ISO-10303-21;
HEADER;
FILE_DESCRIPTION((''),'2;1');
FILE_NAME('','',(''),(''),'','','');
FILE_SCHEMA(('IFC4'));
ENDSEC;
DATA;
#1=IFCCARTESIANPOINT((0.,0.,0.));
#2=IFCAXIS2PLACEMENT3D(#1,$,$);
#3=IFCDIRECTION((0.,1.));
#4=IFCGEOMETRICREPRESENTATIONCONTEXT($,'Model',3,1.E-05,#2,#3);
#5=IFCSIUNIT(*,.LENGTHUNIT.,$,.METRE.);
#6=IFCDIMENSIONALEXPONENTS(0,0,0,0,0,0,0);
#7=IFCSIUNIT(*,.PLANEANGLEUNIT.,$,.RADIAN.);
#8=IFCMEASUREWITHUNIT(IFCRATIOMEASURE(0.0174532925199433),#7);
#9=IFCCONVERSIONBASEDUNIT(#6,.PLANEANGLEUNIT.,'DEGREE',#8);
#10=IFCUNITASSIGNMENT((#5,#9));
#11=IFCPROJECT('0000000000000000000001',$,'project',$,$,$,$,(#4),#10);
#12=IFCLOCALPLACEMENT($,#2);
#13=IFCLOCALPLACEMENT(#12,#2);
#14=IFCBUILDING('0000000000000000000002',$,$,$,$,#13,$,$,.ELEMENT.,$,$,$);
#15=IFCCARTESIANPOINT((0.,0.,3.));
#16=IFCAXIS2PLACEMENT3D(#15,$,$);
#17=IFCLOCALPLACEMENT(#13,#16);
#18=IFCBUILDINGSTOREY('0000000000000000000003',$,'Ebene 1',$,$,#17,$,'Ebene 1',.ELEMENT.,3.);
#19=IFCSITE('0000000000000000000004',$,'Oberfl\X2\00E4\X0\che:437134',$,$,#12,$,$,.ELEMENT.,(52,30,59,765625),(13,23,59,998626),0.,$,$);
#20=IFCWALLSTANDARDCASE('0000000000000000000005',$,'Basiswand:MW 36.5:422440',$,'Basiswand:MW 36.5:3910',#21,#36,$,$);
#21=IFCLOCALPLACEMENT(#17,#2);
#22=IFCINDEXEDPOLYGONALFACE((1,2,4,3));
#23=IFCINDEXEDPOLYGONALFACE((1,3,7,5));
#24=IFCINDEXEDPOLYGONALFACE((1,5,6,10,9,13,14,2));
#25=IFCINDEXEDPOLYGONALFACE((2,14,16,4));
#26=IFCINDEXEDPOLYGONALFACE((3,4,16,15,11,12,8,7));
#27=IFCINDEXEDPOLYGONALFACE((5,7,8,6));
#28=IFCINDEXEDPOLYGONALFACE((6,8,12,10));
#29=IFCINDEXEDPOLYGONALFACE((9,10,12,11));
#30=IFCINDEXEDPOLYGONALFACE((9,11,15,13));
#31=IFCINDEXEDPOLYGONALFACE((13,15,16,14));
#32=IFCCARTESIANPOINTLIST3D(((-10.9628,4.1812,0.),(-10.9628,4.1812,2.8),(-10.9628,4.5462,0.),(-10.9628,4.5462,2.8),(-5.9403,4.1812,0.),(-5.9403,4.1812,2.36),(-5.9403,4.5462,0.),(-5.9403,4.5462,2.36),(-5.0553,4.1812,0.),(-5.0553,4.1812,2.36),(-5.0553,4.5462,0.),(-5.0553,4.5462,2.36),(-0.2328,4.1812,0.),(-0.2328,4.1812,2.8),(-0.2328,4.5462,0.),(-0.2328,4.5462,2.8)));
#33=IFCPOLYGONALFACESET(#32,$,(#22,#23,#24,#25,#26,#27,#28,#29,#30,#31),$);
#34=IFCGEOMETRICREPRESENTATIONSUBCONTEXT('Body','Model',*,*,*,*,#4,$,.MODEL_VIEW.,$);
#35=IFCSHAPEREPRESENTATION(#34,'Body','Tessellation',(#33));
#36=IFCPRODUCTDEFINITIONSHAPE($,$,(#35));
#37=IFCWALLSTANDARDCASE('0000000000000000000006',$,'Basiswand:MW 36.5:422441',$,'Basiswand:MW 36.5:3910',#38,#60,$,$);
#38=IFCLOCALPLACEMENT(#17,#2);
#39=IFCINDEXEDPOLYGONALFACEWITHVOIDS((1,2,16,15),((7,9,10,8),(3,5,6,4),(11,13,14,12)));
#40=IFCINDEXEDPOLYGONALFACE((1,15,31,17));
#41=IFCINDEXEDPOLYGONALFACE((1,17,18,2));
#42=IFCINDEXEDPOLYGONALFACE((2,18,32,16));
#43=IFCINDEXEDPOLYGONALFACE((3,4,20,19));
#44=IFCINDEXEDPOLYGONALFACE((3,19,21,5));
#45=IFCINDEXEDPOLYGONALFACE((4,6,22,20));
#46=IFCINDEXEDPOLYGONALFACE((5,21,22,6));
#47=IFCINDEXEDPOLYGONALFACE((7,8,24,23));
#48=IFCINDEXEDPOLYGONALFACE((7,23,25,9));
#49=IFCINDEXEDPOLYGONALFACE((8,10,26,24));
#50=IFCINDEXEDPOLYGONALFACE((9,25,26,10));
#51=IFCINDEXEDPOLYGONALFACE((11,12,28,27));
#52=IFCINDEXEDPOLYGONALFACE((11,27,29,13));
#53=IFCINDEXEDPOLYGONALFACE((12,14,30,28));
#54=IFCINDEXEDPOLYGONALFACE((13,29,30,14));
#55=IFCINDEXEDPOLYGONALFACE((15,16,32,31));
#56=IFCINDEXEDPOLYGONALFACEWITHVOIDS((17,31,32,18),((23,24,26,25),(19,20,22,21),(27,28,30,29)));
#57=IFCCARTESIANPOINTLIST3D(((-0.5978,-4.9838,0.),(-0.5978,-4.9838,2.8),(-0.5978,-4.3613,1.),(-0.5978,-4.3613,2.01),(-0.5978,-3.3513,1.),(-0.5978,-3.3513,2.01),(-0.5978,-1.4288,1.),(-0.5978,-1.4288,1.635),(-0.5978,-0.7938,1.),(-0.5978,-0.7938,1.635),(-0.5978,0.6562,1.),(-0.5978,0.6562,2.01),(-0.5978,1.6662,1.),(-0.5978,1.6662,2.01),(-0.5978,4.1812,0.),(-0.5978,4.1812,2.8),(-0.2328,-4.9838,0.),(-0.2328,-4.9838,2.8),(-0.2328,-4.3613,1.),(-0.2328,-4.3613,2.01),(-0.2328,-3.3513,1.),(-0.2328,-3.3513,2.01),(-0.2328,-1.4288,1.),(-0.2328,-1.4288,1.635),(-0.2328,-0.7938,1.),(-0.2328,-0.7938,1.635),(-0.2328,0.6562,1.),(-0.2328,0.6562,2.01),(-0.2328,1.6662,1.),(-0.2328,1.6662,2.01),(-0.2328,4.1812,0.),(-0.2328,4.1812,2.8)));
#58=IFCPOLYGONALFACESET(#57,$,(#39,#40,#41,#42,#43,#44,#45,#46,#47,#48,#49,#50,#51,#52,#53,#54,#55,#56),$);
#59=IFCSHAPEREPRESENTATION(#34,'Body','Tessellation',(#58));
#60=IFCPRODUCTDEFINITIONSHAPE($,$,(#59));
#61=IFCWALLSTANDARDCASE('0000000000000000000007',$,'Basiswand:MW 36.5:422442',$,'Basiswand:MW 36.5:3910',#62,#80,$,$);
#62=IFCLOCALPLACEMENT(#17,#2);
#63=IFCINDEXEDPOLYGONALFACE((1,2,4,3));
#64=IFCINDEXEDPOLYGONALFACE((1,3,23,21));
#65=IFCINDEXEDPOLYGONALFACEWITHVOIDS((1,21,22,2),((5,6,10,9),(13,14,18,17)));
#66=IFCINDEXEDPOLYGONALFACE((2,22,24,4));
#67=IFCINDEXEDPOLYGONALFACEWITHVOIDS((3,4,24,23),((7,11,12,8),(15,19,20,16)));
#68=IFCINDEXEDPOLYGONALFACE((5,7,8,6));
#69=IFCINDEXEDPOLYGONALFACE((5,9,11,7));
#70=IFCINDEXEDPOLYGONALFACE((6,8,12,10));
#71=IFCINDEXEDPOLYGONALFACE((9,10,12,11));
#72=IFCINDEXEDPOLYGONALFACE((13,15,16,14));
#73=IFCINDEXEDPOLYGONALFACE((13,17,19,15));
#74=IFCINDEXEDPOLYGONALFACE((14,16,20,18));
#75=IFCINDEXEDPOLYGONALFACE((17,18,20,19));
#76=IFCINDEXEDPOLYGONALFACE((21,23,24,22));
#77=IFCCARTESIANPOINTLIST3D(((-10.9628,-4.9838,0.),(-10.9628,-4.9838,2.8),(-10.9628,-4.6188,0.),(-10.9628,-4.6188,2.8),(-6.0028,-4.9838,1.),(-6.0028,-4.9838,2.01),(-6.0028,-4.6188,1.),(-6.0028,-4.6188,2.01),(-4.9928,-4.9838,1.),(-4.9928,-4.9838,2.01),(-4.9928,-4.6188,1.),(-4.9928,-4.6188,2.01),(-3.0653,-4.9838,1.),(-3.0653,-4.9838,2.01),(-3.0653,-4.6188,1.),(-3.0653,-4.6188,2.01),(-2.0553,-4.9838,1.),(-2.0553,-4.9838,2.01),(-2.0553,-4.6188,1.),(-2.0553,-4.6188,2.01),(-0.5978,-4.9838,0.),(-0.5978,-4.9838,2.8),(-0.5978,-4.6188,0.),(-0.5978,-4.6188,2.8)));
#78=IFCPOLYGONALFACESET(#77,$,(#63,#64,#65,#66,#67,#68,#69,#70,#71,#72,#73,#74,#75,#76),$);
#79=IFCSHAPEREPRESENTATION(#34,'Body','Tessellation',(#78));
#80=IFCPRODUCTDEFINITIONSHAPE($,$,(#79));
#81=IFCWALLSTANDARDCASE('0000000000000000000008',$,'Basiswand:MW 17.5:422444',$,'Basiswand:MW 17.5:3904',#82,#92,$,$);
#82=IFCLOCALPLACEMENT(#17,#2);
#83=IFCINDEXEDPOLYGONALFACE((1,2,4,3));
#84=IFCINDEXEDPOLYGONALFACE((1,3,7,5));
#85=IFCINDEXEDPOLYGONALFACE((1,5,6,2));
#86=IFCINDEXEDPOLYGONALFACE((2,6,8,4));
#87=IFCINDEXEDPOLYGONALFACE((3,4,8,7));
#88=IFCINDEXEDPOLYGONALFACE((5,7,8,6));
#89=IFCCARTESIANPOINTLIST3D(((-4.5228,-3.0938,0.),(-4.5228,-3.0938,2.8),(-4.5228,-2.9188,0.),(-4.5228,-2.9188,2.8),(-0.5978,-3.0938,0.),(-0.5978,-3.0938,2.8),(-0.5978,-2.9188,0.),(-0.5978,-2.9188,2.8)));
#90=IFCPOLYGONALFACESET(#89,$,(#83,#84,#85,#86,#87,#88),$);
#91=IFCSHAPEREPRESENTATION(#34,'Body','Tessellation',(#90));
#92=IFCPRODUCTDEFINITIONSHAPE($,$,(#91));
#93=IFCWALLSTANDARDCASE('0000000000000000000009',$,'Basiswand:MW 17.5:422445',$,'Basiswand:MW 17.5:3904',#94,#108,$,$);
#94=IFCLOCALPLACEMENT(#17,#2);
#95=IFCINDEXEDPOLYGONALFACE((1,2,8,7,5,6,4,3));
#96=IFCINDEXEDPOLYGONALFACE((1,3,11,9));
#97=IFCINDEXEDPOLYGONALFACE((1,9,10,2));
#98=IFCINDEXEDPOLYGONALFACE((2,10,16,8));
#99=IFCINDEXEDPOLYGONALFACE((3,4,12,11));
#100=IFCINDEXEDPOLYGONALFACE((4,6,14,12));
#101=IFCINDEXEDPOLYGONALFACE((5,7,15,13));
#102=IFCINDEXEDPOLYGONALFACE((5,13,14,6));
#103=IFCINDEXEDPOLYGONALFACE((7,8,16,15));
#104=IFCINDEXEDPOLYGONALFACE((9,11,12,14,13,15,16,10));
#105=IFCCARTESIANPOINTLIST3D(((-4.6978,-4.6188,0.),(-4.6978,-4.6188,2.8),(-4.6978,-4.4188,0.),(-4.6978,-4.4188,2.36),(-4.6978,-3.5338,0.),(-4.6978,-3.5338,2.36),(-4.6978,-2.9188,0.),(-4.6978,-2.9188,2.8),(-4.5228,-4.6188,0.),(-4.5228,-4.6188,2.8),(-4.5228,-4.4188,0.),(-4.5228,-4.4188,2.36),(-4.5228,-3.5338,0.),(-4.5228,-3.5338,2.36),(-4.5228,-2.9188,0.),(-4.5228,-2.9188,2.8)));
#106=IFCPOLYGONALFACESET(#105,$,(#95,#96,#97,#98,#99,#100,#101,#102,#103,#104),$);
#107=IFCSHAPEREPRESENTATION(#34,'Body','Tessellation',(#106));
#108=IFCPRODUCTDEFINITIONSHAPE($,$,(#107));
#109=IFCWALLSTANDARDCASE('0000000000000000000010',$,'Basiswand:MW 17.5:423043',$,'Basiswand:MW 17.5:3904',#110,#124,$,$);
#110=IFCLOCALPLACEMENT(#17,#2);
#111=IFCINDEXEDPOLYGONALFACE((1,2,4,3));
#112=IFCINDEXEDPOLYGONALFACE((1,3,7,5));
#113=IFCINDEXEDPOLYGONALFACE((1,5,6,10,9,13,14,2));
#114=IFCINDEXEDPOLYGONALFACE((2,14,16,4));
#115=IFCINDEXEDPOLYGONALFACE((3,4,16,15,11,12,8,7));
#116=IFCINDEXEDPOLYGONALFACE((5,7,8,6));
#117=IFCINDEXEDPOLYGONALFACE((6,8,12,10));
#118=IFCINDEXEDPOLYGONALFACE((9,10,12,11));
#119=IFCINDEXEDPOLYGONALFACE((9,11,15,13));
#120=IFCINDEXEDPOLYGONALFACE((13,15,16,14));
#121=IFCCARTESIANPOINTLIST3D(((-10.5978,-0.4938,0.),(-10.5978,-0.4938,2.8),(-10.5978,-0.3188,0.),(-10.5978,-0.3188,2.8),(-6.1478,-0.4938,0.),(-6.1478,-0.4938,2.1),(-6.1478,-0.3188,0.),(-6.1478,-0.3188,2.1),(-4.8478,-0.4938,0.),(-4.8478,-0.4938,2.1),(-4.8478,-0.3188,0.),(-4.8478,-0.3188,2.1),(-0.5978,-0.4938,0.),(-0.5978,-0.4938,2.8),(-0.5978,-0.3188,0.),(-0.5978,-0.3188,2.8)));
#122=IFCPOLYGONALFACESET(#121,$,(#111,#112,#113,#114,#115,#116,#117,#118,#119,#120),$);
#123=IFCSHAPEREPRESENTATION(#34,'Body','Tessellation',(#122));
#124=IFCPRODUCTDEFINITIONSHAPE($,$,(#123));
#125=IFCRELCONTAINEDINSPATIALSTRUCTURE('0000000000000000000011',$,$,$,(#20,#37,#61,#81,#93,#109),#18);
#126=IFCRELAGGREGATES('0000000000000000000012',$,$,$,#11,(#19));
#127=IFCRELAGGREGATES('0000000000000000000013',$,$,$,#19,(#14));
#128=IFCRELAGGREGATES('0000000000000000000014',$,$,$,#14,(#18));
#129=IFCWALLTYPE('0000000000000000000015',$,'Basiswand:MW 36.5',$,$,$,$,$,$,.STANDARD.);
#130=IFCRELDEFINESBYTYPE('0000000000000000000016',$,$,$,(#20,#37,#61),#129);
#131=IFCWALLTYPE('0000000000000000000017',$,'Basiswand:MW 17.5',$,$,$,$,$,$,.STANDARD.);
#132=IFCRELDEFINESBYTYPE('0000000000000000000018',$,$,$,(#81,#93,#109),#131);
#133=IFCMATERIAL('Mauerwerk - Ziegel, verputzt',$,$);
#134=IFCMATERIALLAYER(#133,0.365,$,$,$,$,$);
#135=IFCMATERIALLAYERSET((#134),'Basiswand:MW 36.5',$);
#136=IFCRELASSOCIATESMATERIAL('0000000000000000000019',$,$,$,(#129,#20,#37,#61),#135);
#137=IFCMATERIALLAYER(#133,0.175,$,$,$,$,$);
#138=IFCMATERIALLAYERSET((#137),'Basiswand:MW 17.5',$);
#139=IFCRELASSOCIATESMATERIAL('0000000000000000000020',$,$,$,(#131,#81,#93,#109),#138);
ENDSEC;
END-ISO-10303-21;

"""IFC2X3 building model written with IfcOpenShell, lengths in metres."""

from ifc_helpers import new_model, entity, si_unit, converted_unit, direction, frame, frame_2d, origin, place, context, subcontext, project, spatial, polyline, rectangle, extrude, clip, bounded_halfspace, material, layer, layer_set, layer_usage, type_object, element, save


model = new_model("IFC2X3")

# Units and contexts
model_context = context("Model", 3, precision=1e-05, world=origin(), true_north=direction((0.0, 1.0)))
body_context = subcontext(model_context, "Body", "Model", "MODEL_VIEW")
ifc_project = project(units=[si_unit("LENGTHUNIT", "METRE"), converted_unit("PLANEANGLEUNIT", "DEGREE", entity("IfcRatioMeasure", 0.0174532925199433), si_unit("PLANEANGLEUNIT", "RADIAN"), dimensions=[0, 0, 0, 0, 0, 0, 0])], contexts=[model_context])

# Site, building, storey
site_placement = place(None, origin())
site = spatial("IfcSite", under=ifc_project, at=site_placement, Name="Oberfläche:437134", CompositionType="ELEMENT", RefLatitude=(52, 30, 59, 765625), RefLongitude=(13, 23, 59, 998626), RefElevation=0.0)
building_placement = place(site_placement, origin())
building = spatial("IfcBuilding", under=site, at=building_placement, CompositionType="ELEMENT")
storey_placement = place(building_placement, frame((0.0, 0.0, 3.0)))
storey = spatial("IfcBuildingStorey", under=building, at=storey_placement, Name="Ebene 1", LongName="Ebene 1", CompositionType="ELEMENT", Elevation=3.0)

# Wall, opening
ifc_material_1 = material(Name="Mauerwerk - Ziegel, verputzt")
ifc_layer_1 = layer(ifc_material_1, 0.365)
ifc_layer_set_1 = layer_set([ifc_layer_1], Name="Basiswand:MW 36.5")
ifc_layer_usage_1 = layer_usage(ifc_layer_set_1, "AXIS2", "NEGATIVE", 0.1825)
wall_type_1 = type_object("IfcWallType", Name="Basiswand:MW 36.5", PredefinedType="STANDARD", material=ifc_layer_set_1)
wall_1_placement = place(storey_placement, frame((-10.9628, 4.3637, 0.0)))
wall_1 = element("IfcWallStandardCase", 1, at=wall_1_placement, inside=storey, type_object=wall_type_1, material=ifc_layer_usage_1, Name="Basiswand:MW 36.5:422440", ObjectType="Basiswand:MW 36.5:3910", context=body_context, shape_type="Clipping", body=[
    clip(extrude(rectangle(XDim=10.73, YDim=0.365, at=frame_2d((5.365, 0.0), x_axis=(-1.0, 0.0))), origin(), (0.0, 0.0, 1.0), 2.8), bounded_halfspace(frame((0.0, -0.1825, 2.8), z_axis=(0.0, 0.0, -1.0), x_axis=(0.0, -1.0, 0.0)), True, frame((0.0, -0.1825, 2.8)), polyline([(0.0, 0.0), (0.365, 0.0), (4.49, 0.0), (4.665, 0.0), (6.265, 0.0), (6.38, 0.0), (10.365, 0.0), (10.73, 0.0), (10.73, 0.365), (0.0, 0.365), (0.0, 0.0)]))),
])
opening_1_placement = place(wall_1_placement, frame((5.9075, 0.1825, 0.0)))
element("IfcOpeningElement", 2, at=opening_1_placement, cuts=wall_1, ObjectType="Opening", context=body_context, shape_type="SweptSolid", body=[
    extrude(rectangle(XDim=2.36, YDim=0.885, at=frame_2d((1.18, 0.4425), x_axis=(1.0, 0.0))), frame((0.0, 0.0, 0.0), z_axis=(0.0, -1.0, 0.0), x_axis=(0.0, 0.0, 1.0)), (0.0, 0.0, 1.0), 0.365),
])

# Walls, openings
ifc_layer_usage_2 = layer_usage(ifc_layer_set_1, "AXIS2", "NEGATIVE", 0.1825)
wall_2_placement = place(storey_placement, frame((-0.4153, 4.1812, 0.0), z_axis=(0.0, 0.0, 1.0), x_axis=(0.0, -1.0, 0.0)))
wall_2 = element("IfcWallStandardCase", 3, at=wall_2_placement, inside=storey, type_object=wall_type_1, material=ifc_layer_usage_2, Name="Basiswand:MW 36.5:422441", ObjectType="Basiswand:MW 36.5:3910", context=body_context, shape_type="Clipping", body=[
    clip(extrude(rectangle(XDim=9.165, YDim=0.365, at=frame_2d((4.5825, 0.0), x_axis=(-1.0, 0.0))), origin(), (0.0, 0.0, 1.0), 2.8), bounded_halfspace(frame((0.0, -0.1825, 2.8), z_axis=(0.0, 0.0, -1.0), x_axis=(1.0, 0.0, 0.0)), True, frame((0.0, -0.1825, 2.8)), polyline([(0.0, 0.0), (2.3, 0.0), (2.415, 0.0), (4.5, 0.0), (4.675, 0.0), (7.1, 0.0), (7.275, 0.0), (8.8, 0.0), (9.165, 0.0), (9.165, 0.365), (0.0, 0.365), (0.0, 0.0)]))),
])
opening_2_placement = place(wall_2_placement, frame((5.61, 0.1825, 1.0)))
element("IfcOpeningElement", 4, at=opening_2_placement, cuts=wall_2, ObjectType="Opening", context=body_context, shape_type="SweptSolid", body=[
    extrude(rectangle(XDim=0.635, YDim=0.635, at=frame_2d((0.3175, 0.3175), x_axis=(1.0, 0.0))), frame((0.0, 0.0, 0.0), z_axis=(0.0, -1.0, 0.0), x_axis=(0.0, 0.0, 1.0)), (0.0, 0.0, 1.0), 0.365),
])
opening_3_placement = place(wall_2_placement, frame((3.525, 0.1825, 1.0)))
element("IfcOpeningElement", 5, at=opening_3_placement, cuts=wall_2, ObjectType="Opening", context=body_context, shape_type="SweptSolid", body=[
    extrude(rectangle(XDim=1.01, YDim=1.01, at=frame_2d((0.505, 0.505), x_axis=(1.0, 0.0))), frame((0.0, 0.0, 0.0), z_axis=(0.0, -1.0, 0.0), x_axis=(0.0, 0.0, 1.0)), (0.0, 0.0, 1.0), 0.365),
])
opening_4_placement = place(wall_2_placement, frame((8.5425, 0.1825, 1.0)))
element("IfcOpeningElement", 6, at=opening_4_placement, cuts=wall_2, ObjectType="Opening", context=body_context, shape_type="SweptSolid", body=[
    extrude(rectangle(XDim=1.01, YDim=1.01, at=frame_2d((0.505, 0.505), x_axis=(1.0, 0.0))), frame((0.0, 0.0, 0.0), z_axis=(0.0, -1.0, 0.0), x_axis=(0.0, 0.0, 1.0)), (0.0, 0.0, 1.0), 0.365),
])
ifc_layer_usage_3 = layer_usage(ifc_layer_set_1, "AXIS2", "NEGATIVE", 0.1825)
wall_3_placement = place(storey_placement, frame((-0.5978, -4.8013, 0.0), z_axis=(0.0, 0.0, 1.0), x_axis=(-1.0, 0.0, 0.0)))
wall_3 = element("IfcWallStandardCase", 7, at=wall_3_placement, inside=storey, type_object=wall_type_1, material=ifc_layer_usage_3, Name="Basiswand:MW 36.5:422442", ObjectType="Basiswand:MW 36.5:3910", context=body_context, shape_type="Clipping", body=[
    clip(extrude(rectangle(XDim=10.365, YDim=0.365, at=frame_2d((5.1825, 0.0), x_axis=(-1.0, 0.0))), origin(), (0.0, 0.0, 1.0), 2.8), bounded_halfspace(frame((0.0, -0.1825, 2.8), z_axis=(0.0, 0.0, -1.0), x_axis=(0.0, 1.0, 0.0)), True, frame((0.0, -0.1825, 2.8)), polyline([(0.0, 0.0), (3.925, 0.0), (4.1, 0.0), (5.7, 0.0), (5.875, 0.0), (10.0, 0.0), (10.365, 0.0), (10.365, 0.365), (0.0, 0.365), (0.0, 0.0)]))),
])
opening_5_placement = place(wall_3_placement, frame((4.395, -0.1825, 1.0)))
element("IfcOpeningElement", 8, at=opening_5_placement, cuts=wall_3, ObjectType="Opening", context=body_context, shape_type="SweptSolid", body=[
    extrude(rectangle(XDim=1.01, YDim=1.01, at=frame_2d((0.505, 0.505), x_axis=(1.0, 0.0))), frame((0.0, 0.0, 0.0), z_axis=(0.0, 1.0, 0.0), x_axis=(0.0, 0.0, 1.0)), (0.0, 0.0, 1.0), 0.365),
])
opening_6_placement = place(wall_3_placement, frame((1.4575, -0.1825, 1.0)))
element("IfcOpeningElement", 9, at=opening_6_placement, cuts=wall_3, ObjectType="Opening", context=body_context, shape_type="SweptSolid", body=[
    extrude(rectangle(XDim=1.01, YDim=1.01, at=frame_2d((0.505, 0.505), x_axis=(1.0, 0.0))), frame((0.0, 0.0, 0.0), z_axis=(0.0, 1.0, 0.0), x_axis=(0.0, 0.0, 1.0)), (0.0, 0.0, 1.0), 0.365),
])

# Wall
ifc_layer_2 = layer(ifc_material_1, 0.175)
ifc_layer_set_2 = layer_set([ifc_layer_2], Name="Basiswand:MW 17.5")
ifc_layer_usage_4 = layer_usage(ifc_layer_set_2, "AXIS2", "NEGATIVE", 0.0875)
wall_type_2 = type_object("IfcWallType", Name="Basiswand:MW 17.5", PredefinedType="STANDARD", material=ifc_layer_set_2)
wall_4_placement = place(storey_placement, frame((-0.5978, -3.0063, 0.0), z_axis=(0.0, 0.0, 1.0), x_axis=(-1.0, 0.0, 0.0)))
element("IfcWallStandardCase", 10, at=wall_4_placement, inside=storey, type_object=wall_type_2, material=ifc_layer_usage_4, Name="Basiswand:MW 17.5:422444", ObjectType="Basiswand:MW 17.5:3904", context=body_context, shape_type="Clipping", body=[
    clip(extrude(rectangle(XDim=3.925, YDim=0.175, at=frame_2d((1.9625, 0.0), x_axis=(-1.0, 0.0))), origin(), (0.0, 0.0, 1.0), 2.8), bounded_halfspace(frame((0.0, -0.0875, 2.8), z_axis=(0.0, 0.0, -1.0), x_axis=(0.0, 1.0, 0.0)), True, frame((0.0, -0.0875, 2.8)), polyline([(0.0, 0.0), (3.925, 0.0), (3.925, 0.175), (0.0, 0.175), (0.0, 0.0)]))),
])

# Walls, openings
ifc_layer_usage_5 = layer_usage(ifc_layer_set_2, "AXIS2", "NEGATIVE", 0.0875)
wall_5_placement = place(storey_placement, frame((-4.6103, -2.9188, 0.0), z_axis=(0.0, 0.0, 1.0), x_axis=(0.0, -1.0, 0.0)))
wall_5 = element("IfcWallStandardCase", 11, at=wall_5_placement, inside=storey, type_object=wall_type_2, material=ifc_layer_usage_5, Name="Basiswand:MW 17.5:422445", ObjectType="Basiswand:MW 17.5:3904", context=body_context, shape_type="Clipping", body=[
    clip(extrude(rectangle(XDim=1.7, YDim=0.175, at=frame_2d((0.85, 0.0), x_axis=(-1.0, 0.0))), origin(), (0.0, 0.0, 1.0), 2.8), bounded_halfspace(frame((0.0, -0.0875, 2.8), z_axis=(0.0, 0.0, -1.0), x_axis=(1.0, 0.0, 0.0)), True, frame((0.0, -0.0875, 2.8)), polyline([(0.0, 0.0), (1.7, 0.0), (1.7, 0.175), (0.175, 0.175), (0.0, 0.175), (0.0, 0.0)]))),
])
opening_7_placement = place(wall_5_placement, frame((0.615, -0.0875, 0.0)))
element("IfcOpeningElement", 12, at=opening_7_placement, cuts=wall_5, ObjectType="Opening", context=body_context, shape_type="SweptSolid", body=[
    extrude(rectangle(XDim=2.36, YDim=0.885, at=frame_2d((1.18, 0.4425), x_axis=(1.0, 0.0))), frame((0.0, 0.0, 0.0), z_axis=(0.0, 1.0, 0.0), x_axis=(0.0, 0.0, 1.0)), (0.0, 0.0, 1.0), 0.175),
])
ifc_layer_usage_6 = layer_usage(ifc_layer_set_2, "AXIS2", "NEGATIVE", 0.0875)
wall_6_placement = place(storey_placement, frame((-10.5978, -0.4063, 0.0)))
wall_6 = element("IfcWallStandardCase", 13, at=wall_6_placement, inside=storey, type_object=wall_type_2, material=ifc_layer_usage_6, Name="Basiswand:MW 17.5:423043", ObjectType="Basiswand:MW 17.5:3904", context=body_context, shape_type="Clipping", body=[
    clip(extrude(rectangle(XDim=10.0, YDim=0.175, at=frame_2d((5.0, 0.0), x_axis=(-1.0, 0.0))), origin(), (0.0, 0.0, 1.0), 2.8), bounded_halfspace(frame((0.0, -0.0875, 2.8), z_axis=(0.0, 0.0, -1.0), x_axis=(0.0, -1.0, 0.0)), True, frame((0.0, -0.0875, 2.8)), polyline([(0.0, 0.0), (4.125, 0.0), (4.3, 0.0), (10.0, 0.0), (10.0, 0.175), (6.015, 0.175), (5.9, 0.175), (4.3, 0.175), (4.125, 0.175), (0.0, 0.175), (0.0, 0.0)]))),
])
opening_8_placement = place(wall_6_placement, origin())
element("IfcOpeningElement", 14, at=opening_8_placement, cuts=wall_6, ObjectType="Opening", context=body_context, shape_type="SweptSolid", body=[
    extrude(rectangle(XDim=2.1, YDim=1.3, at=frame_2d((0.0, 0.0), x_axis=(1.0, 0.0))), frame((5.1, -0.0875, 1.05), z_axis=(0.0, 1.0, 0.0), x_axis=(0.0, 0.0, -1.0)), (0.0, 0.0, 1.0), 0.175),
])

save(model, "model.ifc")
